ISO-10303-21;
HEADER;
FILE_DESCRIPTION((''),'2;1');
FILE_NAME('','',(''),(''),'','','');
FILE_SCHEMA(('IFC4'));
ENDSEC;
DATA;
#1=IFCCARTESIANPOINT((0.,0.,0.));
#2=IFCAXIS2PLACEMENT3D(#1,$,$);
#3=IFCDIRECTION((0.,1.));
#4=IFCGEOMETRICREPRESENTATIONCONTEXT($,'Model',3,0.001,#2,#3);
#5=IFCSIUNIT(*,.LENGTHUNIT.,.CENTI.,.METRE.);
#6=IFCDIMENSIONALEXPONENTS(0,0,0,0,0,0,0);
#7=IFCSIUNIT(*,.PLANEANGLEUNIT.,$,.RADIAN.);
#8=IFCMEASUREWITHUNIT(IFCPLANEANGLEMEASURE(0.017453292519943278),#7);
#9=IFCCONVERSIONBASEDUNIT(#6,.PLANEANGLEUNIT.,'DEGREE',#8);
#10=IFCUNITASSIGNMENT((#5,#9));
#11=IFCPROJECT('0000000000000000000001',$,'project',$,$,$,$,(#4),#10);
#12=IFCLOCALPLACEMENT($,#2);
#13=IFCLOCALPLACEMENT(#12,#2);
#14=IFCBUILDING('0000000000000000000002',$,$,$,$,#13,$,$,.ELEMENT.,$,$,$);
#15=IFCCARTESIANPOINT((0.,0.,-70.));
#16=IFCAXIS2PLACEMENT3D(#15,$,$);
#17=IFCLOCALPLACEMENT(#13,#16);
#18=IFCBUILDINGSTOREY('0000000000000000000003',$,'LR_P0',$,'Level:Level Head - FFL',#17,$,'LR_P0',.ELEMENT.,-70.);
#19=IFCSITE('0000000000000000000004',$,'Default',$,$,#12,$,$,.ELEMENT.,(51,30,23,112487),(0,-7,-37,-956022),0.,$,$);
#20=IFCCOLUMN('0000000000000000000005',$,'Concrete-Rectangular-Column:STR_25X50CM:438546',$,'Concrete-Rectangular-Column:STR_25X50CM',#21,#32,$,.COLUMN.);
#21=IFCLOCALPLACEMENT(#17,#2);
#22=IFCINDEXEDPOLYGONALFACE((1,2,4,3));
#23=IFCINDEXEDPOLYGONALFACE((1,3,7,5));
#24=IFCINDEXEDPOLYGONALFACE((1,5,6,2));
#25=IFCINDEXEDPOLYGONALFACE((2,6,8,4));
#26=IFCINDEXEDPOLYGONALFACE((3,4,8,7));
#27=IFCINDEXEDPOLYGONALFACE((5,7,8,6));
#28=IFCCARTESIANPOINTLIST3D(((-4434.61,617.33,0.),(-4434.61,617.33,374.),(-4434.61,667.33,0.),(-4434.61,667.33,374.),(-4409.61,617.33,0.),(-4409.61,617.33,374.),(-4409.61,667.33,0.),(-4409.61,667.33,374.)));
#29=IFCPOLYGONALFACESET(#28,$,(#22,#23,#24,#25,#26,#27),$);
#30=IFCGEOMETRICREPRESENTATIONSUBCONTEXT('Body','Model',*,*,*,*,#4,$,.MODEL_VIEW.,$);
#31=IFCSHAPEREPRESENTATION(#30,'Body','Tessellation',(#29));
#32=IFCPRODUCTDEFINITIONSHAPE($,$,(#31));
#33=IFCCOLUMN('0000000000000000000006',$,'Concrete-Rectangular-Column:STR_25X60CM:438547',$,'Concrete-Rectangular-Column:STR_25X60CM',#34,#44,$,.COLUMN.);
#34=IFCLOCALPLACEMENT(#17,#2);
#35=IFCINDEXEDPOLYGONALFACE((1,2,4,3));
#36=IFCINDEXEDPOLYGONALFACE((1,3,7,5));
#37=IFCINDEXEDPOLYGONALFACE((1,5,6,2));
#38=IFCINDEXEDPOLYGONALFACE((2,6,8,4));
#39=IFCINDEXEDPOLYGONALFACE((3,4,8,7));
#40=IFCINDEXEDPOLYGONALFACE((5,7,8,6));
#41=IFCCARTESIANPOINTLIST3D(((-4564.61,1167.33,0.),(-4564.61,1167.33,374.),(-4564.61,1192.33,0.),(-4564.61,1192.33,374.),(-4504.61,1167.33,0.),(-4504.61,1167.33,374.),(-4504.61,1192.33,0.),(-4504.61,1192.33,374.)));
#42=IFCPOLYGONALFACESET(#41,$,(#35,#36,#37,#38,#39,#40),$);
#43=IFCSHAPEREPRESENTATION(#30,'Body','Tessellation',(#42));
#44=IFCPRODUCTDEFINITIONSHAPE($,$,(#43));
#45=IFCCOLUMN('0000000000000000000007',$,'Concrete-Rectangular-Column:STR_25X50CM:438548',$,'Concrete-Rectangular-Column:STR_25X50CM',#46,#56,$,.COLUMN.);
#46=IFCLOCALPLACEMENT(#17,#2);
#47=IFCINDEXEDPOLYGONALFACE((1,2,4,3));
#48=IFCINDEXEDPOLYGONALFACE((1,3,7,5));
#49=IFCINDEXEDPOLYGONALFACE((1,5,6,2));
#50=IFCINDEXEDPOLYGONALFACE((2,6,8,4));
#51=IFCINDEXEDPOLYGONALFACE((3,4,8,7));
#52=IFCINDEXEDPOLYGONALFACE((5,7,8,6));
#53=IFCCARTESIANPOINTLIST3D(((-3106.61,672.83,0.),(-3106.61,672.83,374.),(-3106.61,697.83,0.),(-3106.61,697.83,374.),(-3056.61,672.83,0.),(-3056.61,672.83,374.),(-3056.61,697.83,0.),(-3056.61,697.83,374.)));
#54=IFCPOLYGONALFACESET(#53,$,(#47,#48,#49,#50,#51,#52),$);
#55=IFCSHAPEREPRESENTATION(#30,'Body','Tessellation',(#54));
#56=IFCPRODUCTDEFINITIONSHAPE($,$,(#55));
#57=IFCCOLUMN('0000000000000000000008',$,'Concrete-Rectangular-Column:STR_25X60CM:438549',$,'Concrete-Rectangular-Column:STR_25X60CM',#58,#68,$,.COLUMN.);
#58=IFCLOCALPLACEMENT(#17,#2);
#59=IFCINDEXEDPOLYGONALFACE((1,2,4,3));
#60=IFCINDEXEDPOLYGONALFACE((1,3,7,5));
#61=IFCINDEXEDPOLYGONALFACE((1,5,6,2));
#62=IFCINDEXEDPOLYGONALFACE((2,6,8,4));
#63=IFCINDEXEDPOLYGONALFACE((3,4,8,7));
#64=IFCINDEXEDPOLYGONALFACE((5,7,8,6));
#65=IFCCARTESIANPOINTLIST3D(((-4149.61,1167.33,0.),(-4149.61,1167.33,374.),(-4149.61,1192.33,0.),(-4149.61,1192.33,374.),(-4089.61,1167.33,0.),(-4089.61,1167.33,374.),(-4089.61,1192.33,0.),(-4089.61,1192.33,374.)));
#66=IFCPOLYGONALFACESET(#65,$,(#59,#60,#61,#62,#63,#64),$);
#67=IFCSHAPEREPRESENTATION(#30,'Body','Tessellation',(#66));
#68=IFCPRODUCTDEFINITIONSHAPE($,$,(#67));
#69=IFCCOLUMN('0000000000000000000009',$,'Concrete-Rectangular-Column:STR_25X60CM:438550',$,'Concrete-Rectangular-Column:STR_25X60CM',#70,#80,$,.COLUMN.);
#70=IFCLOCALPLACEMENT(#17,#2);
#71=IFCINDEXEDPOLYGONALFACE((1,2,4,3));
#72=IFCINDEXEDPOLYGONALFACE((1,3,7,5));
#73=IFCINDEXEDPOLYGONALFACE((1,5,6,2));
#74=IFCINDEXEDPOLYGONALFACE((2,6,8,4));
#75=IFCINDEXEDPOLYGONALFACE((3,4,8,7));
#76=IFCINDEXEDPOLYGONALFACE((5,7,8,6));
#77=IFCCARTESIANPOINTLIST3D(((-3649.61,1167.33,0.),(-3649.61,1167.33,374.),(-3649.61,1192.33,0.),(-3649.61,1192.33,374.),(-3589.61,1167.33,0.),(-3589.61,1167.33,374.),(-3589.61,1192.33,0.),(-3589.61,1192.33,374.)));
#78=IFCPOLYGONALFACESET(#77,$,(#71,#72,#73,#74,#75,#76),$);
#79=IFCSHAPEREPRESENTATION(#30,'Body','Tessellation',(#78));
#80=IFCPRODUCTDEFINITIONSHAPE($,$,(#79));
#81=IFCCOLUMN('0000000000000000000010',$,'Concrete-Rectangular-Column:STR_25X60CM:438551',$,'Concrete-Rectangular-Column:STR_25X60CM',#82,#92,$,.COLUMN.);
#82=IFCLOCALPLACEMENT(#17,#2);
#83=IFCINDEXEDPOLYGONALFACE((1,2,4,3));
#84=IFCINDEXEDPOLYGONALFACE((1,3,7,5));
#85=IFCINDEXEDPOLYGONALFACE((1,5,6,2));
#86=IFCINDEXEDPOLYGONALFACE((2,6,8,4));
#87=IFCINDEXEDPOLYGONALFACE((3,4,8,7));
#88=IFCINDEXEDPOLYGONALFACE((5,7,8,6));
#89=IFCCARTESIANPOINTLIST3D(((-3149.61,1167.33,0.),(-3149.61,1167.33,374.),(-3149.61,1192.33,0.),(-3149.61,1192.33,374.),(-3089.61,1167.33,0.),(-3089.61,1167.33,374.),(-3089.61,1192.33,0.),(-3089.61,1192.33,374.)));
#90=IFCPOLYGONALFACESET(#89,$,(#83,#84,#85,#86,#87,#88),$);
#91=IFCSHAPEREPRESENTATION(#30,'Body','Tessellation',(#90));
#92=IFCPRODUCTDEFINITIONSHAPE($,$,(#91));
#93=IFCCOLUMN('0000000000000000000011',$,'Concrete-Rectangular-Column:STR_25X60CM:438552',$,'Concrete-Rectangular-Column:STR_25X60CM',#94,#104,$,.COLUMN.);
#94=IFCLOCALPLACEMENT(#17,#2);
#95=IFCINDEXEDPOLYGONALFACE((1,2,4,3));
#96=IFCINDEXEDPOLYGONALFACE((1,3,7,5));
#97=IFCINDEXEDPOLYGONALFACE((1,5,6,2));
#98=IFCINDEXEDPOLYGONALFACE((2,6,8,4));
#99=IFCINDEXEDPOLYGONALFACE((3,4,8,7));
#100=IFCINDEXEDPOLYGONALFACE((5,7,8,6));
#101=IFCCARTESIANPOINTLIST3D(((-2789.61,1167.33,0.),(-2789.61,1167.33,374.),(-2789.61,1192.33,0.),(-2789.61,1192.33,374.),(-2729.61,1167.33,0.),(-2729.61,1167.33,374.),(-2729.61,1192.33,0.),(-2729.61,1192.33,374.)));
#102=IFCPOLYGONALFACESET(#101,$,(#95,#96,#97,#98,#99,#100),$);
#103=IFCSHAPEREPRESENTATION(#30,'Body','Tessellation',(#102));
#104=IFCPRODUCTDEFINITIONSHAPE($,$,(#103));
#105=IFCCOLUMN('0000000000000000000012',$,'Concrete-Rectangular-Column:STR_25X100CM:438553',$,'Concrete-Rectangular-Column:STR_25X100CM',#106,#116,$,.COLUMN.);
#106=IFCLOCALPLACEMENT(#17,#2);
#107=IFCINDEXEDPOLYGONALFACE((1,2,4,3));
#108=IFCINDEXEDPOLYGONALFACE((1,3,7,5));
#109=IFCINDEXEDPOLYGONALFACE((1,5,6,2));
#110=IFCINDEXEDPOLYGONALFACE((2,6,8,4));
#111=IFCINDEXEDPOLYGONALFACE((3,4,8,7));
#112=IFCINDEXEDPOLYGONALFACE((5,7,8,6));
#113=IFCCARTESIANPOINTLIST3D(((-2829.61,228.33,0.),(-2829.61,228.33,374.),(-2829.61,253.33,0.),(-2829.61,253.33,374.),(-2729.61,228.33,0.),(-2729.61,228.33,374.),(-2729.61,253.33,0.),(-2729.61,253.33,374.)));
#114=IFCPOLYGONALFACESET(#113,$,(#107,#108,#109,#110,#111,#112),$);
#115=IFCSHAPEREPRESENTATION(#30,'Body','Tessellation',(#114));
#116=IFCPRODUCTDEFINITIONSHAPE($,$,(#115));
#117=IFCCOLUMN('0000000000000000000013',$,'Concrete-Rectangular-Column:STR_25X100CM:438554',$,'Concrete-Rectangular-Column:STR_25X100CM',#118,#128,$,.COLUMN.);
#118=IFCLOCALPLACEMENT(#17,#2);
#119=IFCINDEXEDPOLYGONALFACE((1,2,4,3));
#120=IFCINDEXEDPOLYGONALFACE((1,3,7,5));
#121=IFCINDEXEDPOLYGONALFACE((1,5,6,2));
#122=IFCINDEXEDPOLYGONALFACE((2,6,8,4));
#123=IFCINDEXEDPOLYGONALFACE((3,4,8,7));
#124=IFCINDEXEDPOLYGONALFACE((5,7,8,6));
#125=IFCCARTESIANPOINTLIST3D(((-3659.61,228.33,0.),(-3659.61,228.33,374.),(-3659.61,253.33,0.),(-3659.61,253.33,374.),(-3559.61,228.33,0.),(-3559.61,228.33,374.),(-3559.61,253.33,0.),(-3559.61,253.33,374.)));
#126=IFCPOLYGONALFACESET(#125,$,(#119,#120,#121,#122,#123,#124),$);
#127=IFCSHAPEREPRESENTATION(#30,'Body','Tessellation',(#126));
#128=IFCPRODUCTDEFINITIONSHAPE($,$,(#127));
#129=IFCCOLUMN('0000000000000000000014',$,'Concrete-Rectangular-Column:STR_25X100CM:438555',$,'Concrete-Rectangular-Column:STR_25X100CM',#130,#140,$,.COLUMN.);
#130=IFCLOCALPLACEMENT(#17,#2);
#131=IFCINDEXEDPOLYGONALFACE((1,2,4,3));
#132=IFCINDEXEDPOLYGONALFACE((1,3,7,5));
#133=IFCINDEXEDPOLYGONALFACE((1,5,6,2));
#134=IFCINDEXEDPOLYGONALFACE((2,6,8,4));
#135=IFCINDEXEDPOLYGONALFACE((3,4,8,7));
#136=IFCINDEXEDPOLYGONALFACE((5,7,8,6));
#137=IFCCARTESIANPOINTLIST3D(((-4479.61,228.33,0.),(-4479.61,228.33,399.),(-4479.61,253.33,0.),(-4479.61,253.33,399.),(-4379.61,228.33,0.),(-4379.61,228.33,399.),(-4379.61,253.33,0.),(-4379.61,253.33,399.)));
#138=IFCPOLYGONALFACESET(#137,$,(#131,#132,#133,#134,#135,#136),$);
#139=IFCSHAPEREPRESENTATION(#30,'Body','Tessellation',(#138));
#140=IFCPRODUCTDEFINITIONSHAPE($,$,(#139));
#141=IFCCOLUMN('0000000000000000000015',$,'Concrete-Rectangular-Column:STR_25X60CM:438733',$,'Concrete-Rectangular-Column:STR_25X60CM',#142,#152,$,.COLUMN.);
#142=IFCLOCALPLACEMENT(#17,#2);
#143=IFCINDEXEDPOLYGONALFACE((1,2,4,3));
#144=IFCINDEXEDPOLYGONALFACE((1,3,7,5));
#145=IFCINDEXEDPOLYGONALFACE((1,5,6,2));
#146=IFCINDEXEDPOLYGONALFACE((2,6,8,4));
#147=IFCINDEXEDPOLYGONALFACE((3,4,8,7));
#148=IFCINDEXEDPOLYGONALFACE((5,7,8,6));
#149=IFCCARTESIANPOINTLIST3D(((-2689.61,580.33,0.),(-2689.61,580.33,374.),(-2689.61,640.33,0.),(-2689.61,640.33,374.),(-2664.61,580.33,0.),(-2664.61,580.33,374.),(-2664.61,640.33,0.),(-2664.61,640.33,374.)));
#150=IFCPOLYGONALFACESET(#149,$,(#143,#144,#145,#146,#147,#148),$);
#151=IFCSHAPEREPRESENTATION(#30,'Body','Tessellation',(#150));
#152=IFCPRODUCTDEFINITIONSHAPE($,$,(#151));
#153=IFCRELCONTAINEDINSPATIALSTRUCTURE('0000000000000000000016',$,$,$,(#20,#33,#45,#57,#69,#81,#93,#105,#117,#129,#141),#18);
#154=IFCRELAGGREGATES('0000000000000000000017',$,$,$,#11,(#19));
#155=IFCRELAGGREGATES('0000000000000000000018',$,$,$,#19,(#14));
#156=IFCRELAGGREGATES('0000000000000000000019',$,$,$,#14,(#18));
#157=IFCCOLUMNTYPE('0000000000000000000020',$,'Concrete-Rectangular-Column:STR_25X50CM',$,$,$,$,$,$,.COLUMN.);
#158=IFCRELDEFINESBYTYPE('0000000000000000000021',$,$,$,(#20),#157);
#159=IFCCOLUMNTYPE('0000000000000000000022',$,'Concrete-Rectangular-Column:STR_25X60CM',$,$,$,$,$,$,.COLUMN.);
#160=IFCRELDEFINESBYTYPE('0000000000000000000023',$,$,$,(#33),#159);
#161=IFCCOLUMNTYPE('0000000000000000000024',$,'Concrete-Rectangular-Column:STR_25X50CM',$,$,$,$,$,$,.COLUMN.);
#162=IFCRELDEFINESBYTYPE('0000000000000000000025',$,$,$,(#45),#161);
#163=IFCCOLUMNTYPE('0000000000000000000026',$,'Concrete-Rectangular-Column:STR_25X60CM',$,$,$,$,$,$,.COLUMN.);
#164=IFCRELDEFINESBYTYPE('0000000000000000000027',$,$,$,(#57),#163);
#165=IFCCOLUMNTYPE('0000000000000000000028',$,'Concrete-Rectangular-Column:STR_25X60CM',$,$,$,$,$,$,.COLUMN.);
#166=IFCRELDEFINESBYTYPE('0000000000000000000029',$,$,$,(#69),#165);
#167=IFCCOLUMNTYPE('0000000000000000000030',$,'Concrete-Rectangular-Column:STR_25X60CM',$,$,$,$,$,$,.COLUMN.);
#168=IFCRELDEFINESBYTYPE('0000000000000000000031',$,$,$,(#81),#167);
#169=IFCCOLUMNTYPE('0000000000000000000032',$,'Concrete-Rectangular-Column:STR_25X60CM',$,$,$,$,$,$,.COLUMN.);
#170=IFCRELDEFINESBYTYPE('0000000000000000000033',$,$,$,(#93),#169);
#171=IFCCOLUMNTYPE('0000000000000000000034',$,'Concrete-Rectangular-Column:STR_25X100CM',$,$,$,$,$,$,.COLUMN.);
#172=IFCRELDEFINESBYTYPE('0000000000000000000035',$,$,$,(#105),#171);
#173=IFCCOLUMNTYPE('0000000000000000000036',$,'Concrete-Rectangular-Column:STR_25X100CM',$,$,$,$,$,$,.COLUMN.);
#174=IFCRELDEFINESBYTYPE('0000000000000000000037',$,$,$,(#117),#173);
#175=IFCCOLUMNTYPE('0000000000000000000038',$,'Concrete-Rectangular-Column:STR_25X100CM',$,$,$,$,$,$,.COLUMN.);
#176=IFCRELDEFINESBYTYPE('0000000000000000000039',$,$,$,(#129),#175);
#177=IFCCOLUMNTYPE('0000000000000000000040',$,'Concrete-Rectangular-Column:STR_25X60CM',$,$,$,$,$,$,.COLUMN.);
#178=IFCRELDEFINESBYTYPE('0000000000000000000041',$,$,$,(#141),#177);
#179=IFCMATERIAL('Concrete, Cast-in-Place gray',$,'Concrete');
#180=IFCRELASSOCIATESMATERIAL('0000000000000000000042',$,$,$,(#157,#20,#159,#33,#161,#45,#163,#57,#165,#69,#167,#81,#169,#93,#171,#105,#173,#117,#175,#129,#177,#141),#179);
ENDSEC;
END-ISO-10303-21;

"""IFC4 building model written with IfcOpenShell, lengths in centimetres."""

from ifc_helpers import new_model, entity, si_unit, converted_unit, direction, frame, origin, place, context, subcontext, project, spatial, indexed_curve, outline, extrude, source, transform, mapped, material, type_object, type_shapes, element, save


model = new_model("IFC4")

# Units and contexts
model_context = context("Model", 3, precision=0.001, world=origin(), true_north=direction((0.0, 1.0)))
body_context = subcontext(model_context, "Body", "Model", "MODEL_VIEW")
ifc_project = project(units=[si_unit("LENGTHUNIT", "METRE", prefix="CENTI"), converted_unit("PLANEANGLEUNIT", "DEGREE", entity("IfcPlaneAngleMeasure", 0.017453292519943278), si_unit("PLANEANGLEUNIT", "RADIAN"), dimensions=[0, 0, 0, 0, 0, 0, 0])], contexts=[model_context])

# Site, building, storey
site_placement = place(None, origin())
site = spatial("IfcSite", under=ifc_project, at=site_placement, Name="Default", CompositionType="ELEMENT", RefLatitude=(51, 30, 23, 112487), RefLongitude=(0, -7, -37, -956022), RefElevation=0.0)
building_placement = place(site_placement, origin())
building = spatial("IfcBuilding", under=site, at=building_placement, CompositionType="ELEMENT")
storey_placement = place(building_placement, frame((0.0, 0.0, -70.0)))
storey = spatial("IfcBuildingStorey", under=building, at=storey_placement, Name="LR_P0", ObjectType="Level:Level Head - FFL", LongName="LR_P0", CompositionType="ELEMENT", Elevation=-70.0)

# Columns
ifc_material_1 = material(Name="Concrete, Cast-in-Place gray", Category="Concrete")
column_type_1 = type_object("IfcColumnType", Name="Concrete-Rectangular-Column:STR_25X50CM", PredefinedType="COLUMN", material=ifc_material_1)
shared_shape_1 = source(origin(), body_context, "Body", "SweptSolid", [
    extrude(outline(indexed_curve([(-12.5, -25.0), (12.5, -25.0), (12.5, 25.0), (-12.5, 25.0), (-12.5, -25.0)], self_intersect=False)), frame((-4422.11, 642.33, -70.0), z_axis=(0.0, 0.0, 1.0), x_axis=(-1.0, 0.0, 0.0)), (0.0, 0.0, 1.0), 374.0),
])
type_shapes(column_type_1, [shared_shape_1])
column_1_placement = place(storey_placement, frame((0.0, 0.0, 70.0)))
element("IfcColumn", 1, at=column_1_placement, inside=storey, type_object=column_type_1, material=ifc_material_1, Name="Concrete-Rectangular-Column:STR_25X50CM:438546", ObjectType="Concrete-Rectangular-Column:STR_25X50CM", PredefinedType="COLUMN", context=body_context, shape_type="MappedRepresentation", body=[
    mapped(shared_shape_1, transform((0.0, 0.0, 0.0), scale=1.0)),
])
column_type_2 = type_object("IfcColumnType", Name="Concrete-Rectangular-Column:STR_25X60CM", PredefinedType="COLUMN", material=ifc_material_1)
shared_shape_2 = source(origin(), body_context, "Body", "SweptSolid", [
    extrude(outline(indexed_curve([(-12.5, -30.0), (12.5, -30.0), (12.5, 30.0), (-12.5, 30.0), (-12.5, -30.0)], self_intersect=False)), frame((-4534.61, 1179.83, -70.0), z_axis=(0.0, 0.0, 1.0), x_axis=(0.0, -1.0, 0.0)), (0.0, 0.0, 1.0), 374.0),
])
type_shapes(column_type_2, [shared_shape_2])
column_2_placement = place(storey_placement, frame((0.0, 0.0, 70.0)))
element("IfcColumn", 2, at=column_2_placement, inside=storey, type_object=column_type_2, material=ifc_material_1, Name="Concrete-Rectangular-Column:STR_25X60CM:438547", ObjectType="Concrete-Rectangular-Column:STR_25X60CM", PredefinedType="COLUMN", context=body_context, shape_type="MappedRepresentation", body=[
    mapped(shared_shape_2, transform((0.0, 0.0, 0.0), scale=1.0)),
])
column_type_3 = type_object("IfcColumnType", Name="Concrete-Rectangular-Column:STR_25X50CM", PredefinedType="COLUMN", material=ifc_material_1)
shared_shape_3 = source(origin(), body_context, "Body", "SweptSolid", [
    extrude(outline(indexed_curve([(-12.5, -25.0), (12.5, -25.0), (12.5, 25.0), (-12.5, 25.0), (-12.5, -25.0)], self_intersect=False)), frame((-3081.61, 685.33, -70.0), z_axis=(0.0, 0.0, 1.0), x_axis=(0.0, -1.0, 0.0)), (0.0, 0.0, 1.0), 374.0),
])
type_shapes(column_type_3, [shared_shape_3])
column_3_placement = place(storey_placement, frame((0.0, 0.0, 70.0)))
element("IfcColumn", 3, at=column_3_placement, inside=storey, type_object=column_type_3, material=ifc_material_1, Name="Concrete-Rectangular-Column:STR_25X50CM:438548", ObjectType="Concrete-Rectangular-Column:STR_25X50CM", PredefinedType="COLUMN", context=body_context, shape_type="MappedRepresentation", body=[
    mapped(shared_shape_3, transform((0.0, 0.0, 0.0), scale=1.0)),
])
column_type_4 = type_object("IfcColumnType", Name="Concrete-Rectangular-Column:STR_25X60CM", PredefinedType="COLUMN", material=ifc_material_1)
shared_shape_4 = source(origin(), body_context, "Body", "SweptSolid", [
    extrude(outline(indexed_curve([(-12.5, -30.0), (12.5, -30.0), (12.5, 30.0), (-12.5, 30.0), (-12.5, -30.0)], self_intersect=False)), frame((-4119.61, 1179.83, -70.0), z_axis=(0.0, 0.0, 1.0), x_axis=(0.0, -1.0, 0.0)), (0.0, 0.0, 1.0), 374.0),
])
type_shapes(column_type_4, [shared_shape_4])
column_4_placement = place(storey_placement, frame((0.0, 0.0, 70.0)))
element("IfcColumn", 4, at=column_4_placement, inside=storey, type_object=column_type_4, material=ifc_material_1, Name="Concrete-Rectangular-Column:STR_25X60CM:438549", ObjectType="Concrete-Rectangular-Column:STR_25X60CM", PredefinedType="COLUMN", context=body_context, shape_type="MappedRepresentation", body=[
    mapped(shared_shape_4, transform((0.0, 0.0, 0.0), scale=1.0)),
])
column_type_5 = type_object("IfcColumnType", Name="Concrete-Rectangular-Column:STR_25X60CM", PredefinedType="COLUMN", material=ifc_material_1)
shared_shape_5 = source(origin(), body_context, "Body", "SweptSolid", [
    extrude(outline(indexed_curve([(-12.5, -30.0), (12.5, -30.0), (12.5, 30.0), (-12.5, 30.0), (-12.5, -30.0)], self_intersect=False)), frame((-3619.61, 1179.83, -70.0), z_axis=(0.0, 0.0, 1.0), x_axis=(0.0, -1.0, 0.0)), (0.0, 0.0, 1.0), 374.0),
])
type_shapes(column_type_5, [shared_shape_5])
column_5_placement = place(storey_placement, frame((0.0, 0.0, 70.0)))
element("IfcColumn", 5, at=column_5_placement, inside=storey, type_object=column_type_5, material=ifc_material_1, Name="Concrete-Rectangular-Column:STR_25X60CM:438550", ObjectType="Concrete-Rectangular-Column:STR_25X60CM", PredefinedType="COLUMN", context=body_context, shape_type="MappedRepresentation", body=[
    mapped(shared_shape_5, transform((0.0, 0.0, 0.0), scale=1.0)),
])
column_type_6 = type_object("IfcColumnType", Name="Concrete-Rectangular-Column:STR_25X60CM", PredefinedType="COLUMN", material=ifc_material_1)
shared_shape_6 = source(origin(), body_context, "Body", "SweptSolid", [
    extrude(outline(indexed_curve([(-12.5, -30.0), (12.5, -30.0), (12.5, 30.0), (-12.5, 30.0), (-12.5, -30.0)], self_intersect=False)), frame((-3119.61, 1179.83, -70.0), z_axis=(0.0, 0.0, 1.0), x_axis=(0.0, -1.0, 0.0)), (0.0, 0.0, 1.0), 374.0),
])
type_shapes(column_type_6, [shared_shape_6])
column_6_placement = place(storey_placement, frame((0.0, 0.0, 70.0)))
element("IfcColumn", 6, at=column_6_placement, inside=storey, type_object=column_type_6, material=ifc_material_1, Name="Concrete-Rectangular-Column:STR_25X60CM:438551", ObjectType="Concrete-Rectangular-Column:STR_25X60CM", PredefinedType="COLUMN", context=body_context, shape_type="MappedRepresentation", body=[
    mapped(shared_shape_6, transform((0.0, 0.0, 0.0), scale=1.0)),
])
column_type_7 = type_object("IfcColumnType", Name="Concrete-Rectangular-Column:STR_25X60CM", PredefinedType="COLUMN", material=ifc_material_1)
shared_shape_7 = source(origin(), body_context, "Body", "SweptSolid", [
    extrude(outline(indexed_curve([(-12.5, -30.0), (12.5, -30.0), (12.5, 30.0), (-12.5, 30.0), (-12.5, -30.0)], self_intersect=False)), frame((-2759.61, 1179.83, -70.0), z_axis=(0.0, 0.0, 1.0), x_axis=(0.0, -1.0, 0.0)), (0.0, 0.0, 1.0), 374.0),
])
type_shapes(column_type_7, [shared_shape_7])
column_7_placement = place(storey_placement, frame((0.0, 0.0, 70.0)))
element("IfcColumn", 7, at=column_7_placement, inside=storey, type_object=column_type_7, material=ifc_material_1, Name="Concrete-Rectangular-Column:STR_25X60CM:438552", ObjectType="Concrete-Rectangular-Column:STR_25X60CM", PredefinedType="COLUMN", context=body_context, shape_type="MappedRepresentation", body=[
    mapped(shared_shape_7, transform((0.0, 0.0, 0.0), scale=1.0)),
])
column_type_8 = type_object("IfcColumnType", Name="Concrete-Rectangular-Column:STR_25X100CM", PredefinedType="COLUMN", material=ifc_material_1)
shared_shape_8 = source(origin(), body_context, "Body", "SweptSolid", [
    extrude(outline(indexed_curve([(-12.5, -50.0), (12.5, -50.0), (12.5, 50.0), (-12.5, 50.0), (-12.5, -50.0)], self_intersect=False)), frame((-2779.61, 240.83, -70.0), z_axis=(0.0, 0.0, 1.0), x_axis=(0.0, -1.0, 0.0)), (0.0, 0.0, 1.0), 374.0),
])
type_shapes(column_type_8, [shared_shape_8])
column_8_placement = place(storey_placement, frame((0.0, 0.0, 70.0)))
element("IfcColumn", 8, at=column_8_placement, inside=storey, type_object=column_type_8, material=ifc_material_1, Name="Concrete-Rectangular-Column:STR_25X100CM:438553", ObjectType="Concrete-Rectangular-Column:STR_25X100CM", PredefinedType="COLUMN", context=body_context, shape_type="MappedRepresentation", body=[
    mapped(shared_shape_8, transform((0.0, 0.0, 0.0), scale=1.0)),
])
column_type_9 = type_object("IfcColumnType", Name="Concrete-Rectangular-Column:STR_25X100CM", PredefinedType="COLUMN", material=ifc_material_1)
shared_shape_9 = source(origin(), body_context, "Body", "SweptSolid", [
    extrude(outline(indexed_curve([(-12.5, -50.0), (12.5, -50.0), (12.5, 50.0), (-12.5, 50.0), (-12.5, -50.0)], self_intersect=False)), frame((-3609.61, 240.83, -70.0), z_axis=(0.0, 0.0, 1.0), x_axis=(0.0, -1.0, 0.0)), (0.0, 0.0, 1.0), 374.0),
])
type_shapes(column_type_9, [shared_shape_9])
column_9_placement = place(storey_placement, frame((0.0, 0.0, 70.0)))
element("IfcColumn", 9, at=column_9_placement, inside=storey, type_object=column_type_9, material=ifc_material_1, Name="Concrete-Rectangular-Column:STR_25X100CM:438554", ObjectType="Concrete-Rectangular-Column:STR_25X100CM", PredefinedType="COLUMN", context=body_context, shape_type="MappedRepresentation", body=[
    mapped(shared_shape_9, transform((0.0, 0.0, 0.0), scale=1.0)),
])
column_type_10 = type_object("IfcColumnType", Name="Concrete-Rectangular-Column:STR_25X100CM", PredefinedType="COLUMN", material=ifc_material_1)
shared_shape_10 = source(origin(), body_context, "Body", "SweptSolid", [
    extrude(outline(indexed_curve([(-12.5, -50.0), (12.5, -50.0), (12.5, 50.0), (-12.5, 50.0), (-12.5, -50.0)], self_intersect=False)), frame((-4429.61, 240.83, -70.0), z_axis=(0.0, 0.0, 1.0), x_axis=(0.0, -1.0, 0.0)), (0.0, 0.0, 1.0), 399.0),
])
type_shapes(column_type_10, [shared_shape_10])
column_10_placement = place(storey_placement, frame((0.0, 0.0, 70.0)))
element("IfcColumn", 10, at=column_10_placement, inside=storey, type_object=column_type_10, material=ifc_material_1, Name="Concrete-Rectangular-Column:STR_25X100CM:438555", ObjectType="Concrete-Rectangular-Column:STR_25X100CM", PredefinedType="COLUMN", context=body_context, shape_type="MappedRepresentation", body=[
    mapped(shared_shape_10, transform((0.0, 0.0, 0.0), scale=1.0)),
])
column_type_11 = type_object("IfcColumnType", Name="Concrete-Rectangular-Column:STR_25X60CM", PredefinedType="COLUMN", material=ifc_material_1)
shared_shape_11 = source(origin(), body_context, "Body", "SweptSolid", [
    extrude(outline(indexed_curve([(-12.5, -30.0), (12.5, -30.0), (12.5, 30.0), (-12.5, 30.0), (-12.5, -30.0)], self_intersect=False)), frame((-2677.11, 610.33, -70.0), z_axis=(0.0, 0.0, 1.0), x_axis=(-1.0, 0.0, 0.0)), (0.0, 0.0, 1.0), 374.0),
])
type_shapes(column_type_11, [shared_shape_11])
column_11_placement = place(storey_placement, frame((0.0, 0.0, 70.0)))
element("IfcColumn", 11, at=column_11_placement, inside=storey, type_object=column_type_11, material=ifc_material_1, Name="Concrete-Rectangular-Column:STR_25X60CM:438733", ObjectType="Concrete-Rectangular-Column:STR_25X60CM", PredefinedType="COLUMN", context=body_context, shape_type="MappedRepresentation", body=[
    mapped(shared_shape_11, transform((0.0, 0.0, 0.0), scale=1.0)),
])

save(model, "model.ifc")
